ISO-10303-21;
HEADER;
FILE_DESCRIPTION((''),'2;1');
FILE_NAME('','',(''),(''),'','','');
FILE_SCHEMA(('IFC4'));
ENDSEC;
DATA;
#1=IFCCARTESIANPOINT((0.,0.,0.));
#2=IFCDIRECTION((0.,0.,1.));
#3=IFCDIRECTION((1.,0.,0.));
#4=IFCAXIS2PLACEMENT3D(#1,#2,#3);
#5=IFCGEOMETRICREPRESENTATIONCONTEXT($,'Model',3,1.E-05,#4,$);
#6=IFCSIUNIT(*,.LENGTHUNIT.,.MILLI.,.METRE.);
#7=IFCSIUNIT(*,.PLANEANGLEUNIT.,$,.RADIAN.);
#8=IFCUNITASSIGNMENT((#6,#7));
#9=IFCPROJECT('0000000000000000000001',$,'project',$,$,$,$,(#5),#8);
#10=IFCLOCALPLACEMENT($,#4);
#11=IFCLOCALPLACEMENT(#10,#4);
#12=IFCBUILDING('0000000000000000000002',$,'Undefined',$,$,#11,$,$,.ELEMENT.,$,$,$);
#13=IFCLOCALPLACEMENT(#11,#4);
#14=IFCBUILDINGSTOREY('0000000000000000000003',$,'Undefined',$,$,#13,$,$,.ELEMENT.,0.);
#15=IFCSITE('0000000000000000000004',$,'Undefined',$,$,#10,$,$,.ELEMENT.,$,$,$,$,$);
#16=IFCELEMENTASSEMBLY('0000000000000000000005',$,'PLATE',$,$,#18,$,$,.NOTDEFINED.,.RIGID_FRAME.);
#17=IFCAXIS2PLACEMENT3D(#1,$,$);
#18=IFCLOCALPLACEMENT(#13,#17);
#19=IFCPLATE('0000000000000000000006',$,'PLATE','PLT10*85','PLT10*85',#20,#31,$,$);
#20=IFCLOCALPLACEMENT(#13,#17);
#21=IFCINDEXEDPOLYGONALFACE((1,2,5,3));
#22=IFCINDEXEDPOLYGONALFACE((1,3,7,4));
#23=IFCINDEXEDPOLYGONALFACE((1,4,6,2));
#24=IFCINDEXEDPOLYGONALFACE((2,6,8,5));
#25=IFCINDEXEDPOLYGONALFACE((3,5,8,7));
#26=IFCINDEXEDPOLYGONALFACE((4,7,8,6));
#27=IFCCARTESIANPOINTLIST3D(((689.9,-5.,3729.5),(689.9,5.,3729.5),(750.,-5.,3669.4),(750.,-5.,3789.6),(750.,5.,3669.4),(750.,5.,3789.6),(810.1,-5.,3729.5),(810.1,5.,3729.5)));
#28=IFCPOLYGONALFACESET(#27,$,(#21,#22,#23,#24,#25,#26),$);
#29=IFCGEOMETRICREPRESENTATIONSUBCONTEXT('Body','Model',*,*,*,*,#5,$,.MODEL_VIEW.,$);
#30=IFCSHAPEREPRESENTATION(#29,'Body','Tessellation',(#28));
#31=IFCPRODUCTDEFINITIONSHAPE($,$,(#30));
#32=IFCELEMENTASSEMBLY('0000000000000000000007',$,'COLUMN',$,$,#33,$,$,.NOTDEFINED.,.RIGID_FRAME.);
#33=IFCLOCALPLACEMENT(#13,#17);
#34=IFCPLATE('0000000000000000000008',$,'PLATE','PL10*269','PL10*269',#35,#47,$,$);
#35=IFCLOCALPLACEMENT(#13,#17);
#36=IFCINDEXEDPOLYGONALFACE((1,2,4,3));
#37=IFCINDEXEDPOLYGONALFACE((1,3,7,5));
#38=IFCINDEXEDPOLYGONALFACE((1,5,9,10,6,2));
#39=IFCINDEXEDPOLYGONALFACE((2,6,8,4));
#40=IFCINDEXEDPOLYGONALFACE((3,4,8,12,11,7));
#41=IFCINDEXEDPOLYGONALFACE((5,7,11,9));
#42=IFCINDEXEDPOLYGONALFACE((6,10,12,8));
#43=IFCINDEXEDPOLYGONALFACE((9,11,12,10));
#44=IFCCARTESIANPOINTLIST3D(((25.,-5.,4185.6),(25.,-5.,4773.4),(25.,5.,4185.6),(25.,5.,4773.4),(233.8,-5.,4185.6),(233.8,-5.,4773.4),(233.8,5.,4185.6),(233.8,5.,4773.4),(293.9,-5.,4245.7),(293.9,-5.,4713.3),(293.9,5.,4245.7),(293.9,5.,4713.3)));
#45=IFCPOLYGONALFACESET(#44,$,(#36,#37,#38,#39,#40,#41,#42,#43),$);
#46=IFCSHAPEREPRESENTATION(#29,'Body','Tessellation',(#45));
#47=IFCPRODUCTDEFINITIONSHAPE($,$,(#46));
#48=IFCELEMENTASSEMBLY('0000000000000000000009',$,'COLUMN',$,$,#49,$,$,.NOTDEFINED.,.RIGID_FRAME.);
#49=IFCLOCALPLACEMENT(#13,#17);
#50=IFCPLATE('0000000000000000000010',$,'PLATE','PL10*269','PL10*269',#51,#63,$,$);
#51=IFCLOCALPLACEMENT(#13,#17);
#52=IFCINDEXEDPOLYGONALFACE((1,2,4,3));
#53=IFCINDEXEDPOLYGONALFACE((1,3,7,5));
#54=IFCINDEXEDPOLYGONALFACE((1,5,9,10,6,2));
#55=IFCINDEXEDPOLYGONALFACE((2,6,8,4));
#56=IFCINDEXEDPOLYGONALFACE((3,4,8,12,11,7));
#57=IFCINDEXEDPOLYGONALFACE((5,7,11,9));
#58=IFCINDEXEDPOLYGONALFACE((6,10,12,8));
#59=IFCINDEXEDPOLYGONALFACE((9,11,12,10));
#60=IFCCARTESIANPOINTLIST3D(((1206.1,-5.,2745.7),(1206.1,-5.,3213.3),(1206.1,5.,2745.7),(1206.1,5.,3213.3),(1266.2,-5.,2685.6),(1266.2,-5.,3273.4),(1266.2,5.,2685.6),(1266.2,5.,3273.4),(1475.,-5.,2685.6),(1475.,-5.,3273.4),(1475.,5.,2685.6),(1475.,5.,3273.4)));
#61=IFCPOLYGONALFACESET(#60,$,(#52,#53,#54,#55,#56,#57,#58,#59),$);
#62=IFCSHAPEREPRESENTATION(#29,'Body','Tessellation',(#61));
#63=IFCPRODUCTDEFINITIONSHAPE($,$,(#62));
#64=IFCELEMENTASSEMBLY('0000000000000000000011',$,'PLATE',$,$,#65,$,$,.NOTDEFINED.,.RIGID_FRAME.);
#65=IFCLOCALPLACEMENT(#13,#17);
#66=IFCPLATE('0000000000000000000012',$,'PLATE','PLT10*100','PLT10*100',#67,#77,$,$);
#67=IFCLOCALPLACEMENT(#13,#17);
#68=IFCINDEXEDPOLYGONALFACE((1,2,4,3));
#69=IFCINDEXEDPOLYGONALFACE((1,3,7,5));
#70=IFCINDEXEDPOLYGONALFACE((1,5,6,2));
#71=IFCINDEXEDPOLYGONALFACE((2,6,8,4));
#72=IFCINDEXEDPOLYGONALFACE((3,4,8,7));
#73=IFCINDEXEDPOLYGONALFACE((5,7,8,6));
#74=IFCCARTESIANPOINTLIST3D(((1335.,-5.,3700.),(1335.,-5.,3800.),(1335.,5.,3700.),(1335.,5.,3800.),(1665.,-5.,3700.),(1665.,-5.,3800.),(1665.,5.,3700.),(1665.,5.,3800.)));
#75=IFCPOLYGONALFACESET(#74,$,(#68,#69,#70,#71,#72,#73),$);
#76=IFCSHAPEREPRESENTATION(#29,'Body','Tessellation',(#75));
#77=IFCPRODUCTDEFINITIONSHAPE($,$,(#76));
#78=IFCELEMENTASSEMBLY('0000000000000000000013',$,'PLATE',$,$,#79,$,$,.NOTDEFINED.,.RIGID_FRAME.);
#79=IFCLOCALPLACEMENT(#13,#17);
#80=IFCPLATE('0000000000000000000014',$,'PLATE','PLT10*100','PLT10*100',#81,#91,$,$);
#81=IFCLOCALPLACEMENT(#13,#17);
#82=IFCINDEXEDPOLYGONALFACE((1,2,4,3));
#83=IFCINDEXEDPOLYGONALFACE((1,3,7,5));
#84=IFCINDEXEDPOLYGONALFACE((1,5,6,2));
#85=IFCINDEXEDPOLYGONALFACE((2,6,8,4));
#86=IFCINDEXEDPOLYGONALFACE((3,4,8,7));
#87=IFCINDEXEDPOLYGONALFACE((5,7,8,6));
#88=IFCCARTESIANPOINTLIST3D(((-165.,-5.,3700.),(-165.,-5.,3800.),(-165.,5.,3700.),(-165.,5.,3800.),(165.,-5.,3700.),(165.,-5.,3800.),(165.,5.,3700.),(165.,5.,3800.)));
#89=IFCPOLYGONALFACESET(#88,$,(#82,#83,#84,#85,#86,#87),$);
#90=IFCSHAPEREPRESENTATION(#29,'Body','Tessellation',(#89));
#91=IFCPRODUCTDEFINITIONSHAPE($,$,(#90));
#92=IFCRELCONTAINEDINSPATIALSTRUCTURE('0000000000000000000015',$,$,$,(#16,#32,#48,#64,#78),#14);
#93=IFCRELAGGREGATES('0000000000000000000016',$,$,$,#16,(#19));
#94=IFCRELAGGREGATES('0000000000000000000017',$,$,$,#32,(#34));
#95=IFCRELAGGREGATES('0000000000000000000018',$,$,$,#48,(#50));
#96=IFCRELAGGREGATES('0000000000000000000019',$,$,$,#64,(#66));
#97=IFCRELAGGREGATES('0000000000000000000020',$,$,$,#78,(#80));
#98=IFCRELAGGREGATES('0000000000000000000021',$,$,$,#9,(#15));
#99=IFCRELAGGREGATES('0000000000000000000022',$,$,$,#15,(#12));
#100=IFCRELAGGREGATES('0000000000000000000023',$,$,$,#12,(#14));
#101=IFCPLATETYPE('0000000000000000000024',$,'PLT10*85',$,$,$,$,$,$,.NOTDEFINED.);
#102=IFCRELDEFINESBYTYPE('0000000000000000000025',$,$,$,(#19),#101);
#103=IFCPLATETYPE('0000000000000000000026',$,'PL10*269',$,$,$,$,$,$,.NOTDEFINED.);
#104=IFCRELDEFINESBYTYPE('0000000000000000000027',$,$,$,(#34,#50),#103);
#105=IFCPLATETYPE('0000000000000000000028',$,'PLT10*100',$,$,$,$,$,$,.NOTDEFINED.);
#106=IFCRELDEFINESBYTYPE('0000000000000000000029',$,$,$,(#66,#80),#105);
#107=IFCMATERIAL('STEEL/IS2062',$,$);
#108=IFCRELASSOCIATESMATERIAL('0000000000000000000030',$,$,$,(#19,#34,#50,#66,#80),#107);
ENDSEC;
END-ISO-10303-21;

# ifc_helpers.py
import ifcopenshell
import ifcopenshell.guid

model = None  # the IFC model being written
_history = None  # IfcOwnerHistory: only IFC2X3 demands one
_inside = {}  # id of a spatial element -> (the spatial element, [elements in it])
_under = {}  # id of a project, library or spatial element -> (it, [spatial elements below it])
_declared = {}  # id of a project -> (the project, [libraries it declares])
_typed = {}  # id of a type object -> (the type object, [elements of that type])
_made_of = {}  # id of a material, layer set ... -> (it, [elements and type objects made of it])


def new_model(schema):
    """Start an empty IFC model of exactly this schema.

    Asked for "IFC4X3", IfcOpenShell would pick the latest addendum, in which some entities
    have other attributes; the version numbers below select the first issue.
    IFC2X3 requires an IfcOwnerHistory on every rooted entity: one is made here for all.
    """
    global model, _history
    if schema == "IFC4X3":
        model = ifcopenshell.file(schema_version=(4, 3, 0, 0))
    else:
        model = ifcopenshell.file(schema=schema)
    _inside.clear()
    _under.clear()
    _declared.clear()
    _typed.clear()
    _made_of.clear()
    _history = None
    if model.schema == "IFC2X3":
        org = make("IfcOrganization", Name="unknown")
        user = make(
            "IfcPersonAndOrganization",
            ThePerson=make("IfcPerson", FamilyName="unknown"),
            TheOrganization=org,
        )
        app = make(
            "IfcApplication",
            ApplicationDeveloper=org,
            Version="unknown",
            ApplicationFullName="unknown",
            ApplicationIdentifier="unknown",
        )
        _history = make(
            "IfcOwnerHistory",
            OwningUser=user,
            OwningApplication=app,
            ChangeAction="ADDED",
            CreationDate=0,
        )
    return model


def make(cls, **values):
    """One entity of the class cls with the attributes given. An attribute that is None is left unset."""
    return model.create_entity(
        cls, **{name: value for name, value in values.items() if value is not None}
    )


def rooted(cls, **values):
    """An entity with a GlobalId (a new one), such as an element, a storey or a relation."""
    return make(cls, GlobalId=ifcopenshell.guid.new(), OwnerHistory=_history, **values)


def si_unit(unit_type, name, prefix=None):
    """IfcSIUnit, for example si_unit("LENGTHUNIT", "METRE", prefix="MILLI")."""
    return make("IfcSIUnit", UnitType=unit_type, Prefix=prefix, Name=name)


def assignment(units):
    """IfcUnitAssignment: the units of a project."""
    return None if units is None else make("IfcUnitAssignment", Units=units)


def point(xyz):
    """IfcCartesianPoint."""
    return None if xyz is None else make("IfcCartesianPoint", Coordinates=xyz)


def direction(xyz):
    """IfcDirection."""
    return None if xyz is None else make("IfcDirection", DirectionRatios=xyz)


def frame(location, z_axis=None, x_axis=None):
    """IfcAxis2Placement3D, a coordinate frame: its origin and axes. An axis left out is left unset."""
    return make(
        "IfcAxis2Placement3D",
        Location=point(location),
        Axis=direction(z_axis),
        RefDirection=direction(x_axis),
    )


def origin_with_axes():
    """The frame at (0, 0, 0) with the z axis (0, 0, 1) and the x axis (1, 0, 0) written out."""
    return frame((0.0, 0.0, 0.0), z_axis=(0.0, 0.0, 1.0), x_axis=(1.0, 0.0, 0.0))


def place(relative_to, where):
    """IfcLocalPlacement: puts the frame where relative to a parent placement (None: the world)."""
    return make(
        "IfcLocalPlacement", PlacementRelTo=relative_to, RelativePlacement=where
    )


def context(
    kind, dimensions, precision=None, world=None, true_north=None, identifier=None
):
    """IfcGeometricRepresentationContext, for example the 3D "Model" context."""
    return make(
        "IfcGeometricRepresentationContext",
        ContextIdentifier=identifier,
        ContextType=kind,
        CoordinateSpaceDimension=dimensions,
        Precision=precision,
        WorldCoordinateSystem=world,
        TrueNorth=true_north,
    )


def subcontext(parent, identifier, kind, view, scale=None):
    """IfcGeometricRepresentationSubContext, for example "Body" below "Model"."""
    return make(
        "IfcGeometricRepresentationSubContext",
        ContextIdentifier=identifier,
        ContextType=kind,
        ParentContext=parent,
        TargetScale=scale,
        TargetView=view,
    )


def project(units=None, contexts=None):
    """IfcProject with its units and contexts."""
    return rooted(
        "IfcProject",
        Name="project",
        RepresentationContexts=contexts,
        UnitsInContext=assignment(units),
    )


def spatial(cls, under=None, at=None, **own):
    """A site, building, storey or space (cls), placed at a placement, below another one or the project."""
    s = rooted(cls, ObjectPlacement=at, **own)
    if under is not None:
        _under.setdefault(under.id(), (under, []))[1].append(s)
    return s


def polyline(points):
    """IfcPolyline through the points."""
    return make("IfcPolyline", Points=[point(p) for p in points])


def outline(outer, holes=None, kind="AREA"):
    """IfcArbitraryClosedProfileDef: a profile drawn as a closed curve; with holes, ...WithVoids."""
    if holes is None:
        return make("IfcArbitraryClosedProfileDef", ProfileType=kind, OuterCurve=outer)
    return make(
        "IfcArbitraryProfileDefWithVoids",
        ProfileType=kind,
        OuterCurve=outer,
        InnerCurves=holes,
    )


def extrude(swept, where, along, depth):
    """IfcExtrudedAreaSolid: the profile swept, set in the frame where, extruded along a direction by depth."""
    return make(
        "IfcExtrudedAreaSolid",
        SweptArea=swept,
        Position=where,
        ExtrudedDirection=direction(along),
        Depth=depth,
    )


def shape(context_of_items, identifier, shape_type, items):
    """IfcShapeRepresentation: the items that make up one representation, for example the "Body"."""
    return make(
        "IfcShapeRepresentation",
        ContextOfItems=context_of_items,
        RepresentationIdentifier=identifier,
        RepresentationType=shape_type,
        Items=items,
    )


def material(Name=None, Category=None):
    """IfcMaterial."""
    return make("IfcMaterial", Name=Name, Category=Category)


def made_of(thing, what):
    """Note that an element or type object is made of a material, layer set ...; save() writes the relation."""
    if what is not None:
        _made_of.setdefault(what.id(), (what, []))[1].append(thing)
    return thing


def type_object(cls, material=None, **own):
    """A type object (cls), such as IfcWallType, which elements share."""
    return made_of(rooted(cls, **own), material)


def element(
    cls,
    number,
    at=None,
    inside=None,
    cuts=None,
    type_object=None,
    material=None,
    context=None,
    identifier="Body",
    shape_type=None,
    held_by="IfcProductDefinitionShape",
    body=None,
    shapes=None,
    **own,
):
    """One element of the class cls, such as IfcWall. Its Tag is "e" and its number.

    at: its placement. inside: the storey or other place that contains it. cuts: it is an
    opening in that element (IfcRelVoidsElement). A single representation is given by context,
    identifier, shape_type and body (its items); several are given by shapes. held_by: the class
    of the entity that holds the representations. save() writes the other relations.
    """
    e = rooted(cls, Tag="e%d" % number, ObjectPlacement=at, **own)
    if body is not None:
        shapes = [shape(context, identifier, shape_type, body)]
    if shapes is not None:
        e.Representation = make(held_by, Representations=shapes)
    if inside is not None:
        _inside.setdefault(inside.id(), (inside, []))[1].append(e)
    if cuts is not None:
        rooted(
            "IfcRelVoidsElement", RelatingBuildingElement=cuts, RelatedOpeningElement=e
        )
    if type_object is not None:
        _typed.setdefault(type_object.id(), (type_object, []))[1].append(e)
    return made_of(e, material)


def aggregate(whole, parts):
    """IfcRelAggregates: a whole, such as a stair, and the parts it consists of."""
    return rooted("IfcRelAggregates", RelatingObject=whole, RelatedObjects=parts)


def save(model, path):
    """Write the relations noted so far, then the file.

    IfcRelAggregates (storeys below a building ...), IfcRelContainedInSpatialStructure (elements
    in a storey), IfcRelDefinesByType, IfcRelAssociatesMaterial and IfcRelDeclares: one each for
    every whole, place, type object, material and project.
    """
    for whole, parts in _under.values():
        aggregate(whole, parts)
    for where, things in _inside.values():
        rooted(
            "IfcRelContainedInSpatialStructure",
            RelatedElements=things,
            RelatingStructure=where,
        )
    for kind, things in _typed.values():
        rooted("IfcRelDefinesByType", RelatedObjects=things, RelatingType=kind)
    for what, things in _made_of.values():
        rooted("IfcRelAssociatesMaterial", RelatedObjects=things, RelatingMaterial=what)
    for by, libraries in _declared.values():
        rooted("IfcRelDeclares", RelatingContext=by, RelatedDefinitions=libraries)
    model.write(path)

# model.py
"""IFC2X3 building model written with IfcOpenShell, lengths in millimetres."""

from ifc_helpers import new_model, si_unit, frame, origin_with_axes, place, context, subcontext, project, spatial, polyline, outline, extrude, material, type_object, element, aggregate, save


model = new_model("IFC2X3")

# Units and contexts
model_context = context("Model", 3, precision=1e-05, world=origin_with_axes())
body_context = subcontext(model_context, "Body", "Model", "MODEL_VIEW")
ifc_project = project(units=[si_unit("LENGTHUNIT", "METRE", prefix="MILLI"), si_unit("PLANEANGLEUNIT", "RADIAN")], contexts=[model_context])

# Site, building, storey
site_placement = place(None, origin_with_axes())
site = spatial("IfcSite", under=ifc_project, at=site_placement, Name="Undefined", CompositionType="ELEMENT")
building_placement = place(site_placement, origin_with_axes())
building = spatial("IfcBuilding", under=site, at=building_placement, Name="Undefined", CompositionType="ELEMENT")
storey_placement = place(building_placement, origin_with_axes())
storey = spatial("IfcBuildingStorey", under=building, at=storey_placement, Name="Undefined", CompositionType="ELEMENT", Elevation=0.0)

# Shared definitions
ifc_material = material(Name="STEEL/IS2062")

# Element assemblies, plates
assembly_1_placement = place(storey_placement, origin_with_axes())
assembly_1 = element("IfcElementAssembly", 1, at=assembly_1_placement, inside=storey, Name="PLATE", AssemblyPlace="NOTDEFINED", PredefinedType="RIGID_FRAME")
plate_type_1 = type_object("IfcPlateType", Name="PLT10*85", PredefinedType="NOTDEFINED")
plate_1_placement = place(assembly_1_placement, frame((750.0, 0.0, 3789.6), z_axis=(0.0, -1.0, 0.0), x_axis=(-0.707107, 0.0, -0.707107)))
plate_1 = element("IfcPlate", 2, at=plate_1_placement, type_object=plate_type_1, material=ifc_material, Name="PLATE", Description="PLT10*85", ObjectType="PLT10*85", context=body_context, shape_type="SweptSolid", body=[
    extrude(outline(polyline([(0.0, 0.0), (85.0, 0.0), (85.0, 85.0), (0.0, 85.0), (0.0, 0.0)])), frame((0.0, 0.0, -5.0), z_axis=(0.0, 0.0, 1.0), x_axis=(1.0, 0.0, 0.0)), (0.0, 0.0, 1.0), 10.0),
])
aggregate(assembly_1, [plate_1])
assembly_2_placement = place(storey_placement, origin_with_axes())
assembly_2 = element("IfcElementAssembly", 3, at=assembly_2_placement, inside=storey, Name="COLUMN", AssemblyPlace="NOTDEFINED", PredefinedType="RIGID_FRAME")
plate_type_2 = type_object("IfcPlateType", Name="PL10*269", PredefinedType="NOTDEFINED")
plate_2_placement = place(assembly_2_placement, frame((25.0, 0.0, 4185.6), z_axis=(0.0, 1.0, 0.0), x_axis=(0.0, 0.0, 1.0)))
plate_2 = element("IfcPlate", 4, at=plate_2_placement, type_object=plate_type_2, material=ifc_material, Name="PLATE", Description="PL10*269", ObjectType="PL10*269", context=body_context, shape_type="SweptSolid", body=[
    extrude(outline(polyline([(0.0, 0.0), (587.8, 0.0), (587.8, 208.8), (527.7, 268.9), (60.1, 268.9), (0.0, 208.8), (0.0, 0.0)])), frame((0.0, 0.0, -5.0), z_axis=(0.0, 0.0, 1.0), x_axis=(1.0, 0.0, 0.0)), (0.0, 0.0, 1.0), 10.0),
])
aggregate(assembly_2, [plate_2])
assembly_3_placement = place(storey_placement, origin_with_axes())
assembly_3 = element("IfcElementAssembly", 5, at=assembly_3_placement, inside=storey, Name="COLUMN", AssemblyPlace="NOTDEFINED", PredefinedType="RIGID_FRAME")
plate_3_placement = place(assembly_3_placement, frame((1475.0, 0.0, 3273.4), z_axis=(0.0, 1.0, 0.0), x_axis=(0.0, 0.0, -1.0)))
plate_3 = element("IfcPlate", 6, at=plate_3_placement, type_object=plate_type_2, material=ifc_material, Name="PLATE", Description="PL10*269", ObjectType="PL10*269", context=body_context, shape_type="SweptSolid", body=[
    extrude(outline(polyline([(0.0, 0.0), (587.8, 0.0), (587.8, 208.8), (527.7, 268.9), (60.1, 268.9), (0.0, 208.8), (0.0, 0.0)])), frame((0.0, 0.0, -5.0), z_axis=(0.0, 0.0, 1.0), x_axis=(1.0, 0.0, 0.0)), (0.0, 0.0, 1.0), 10.0),
])
aggregate(assembly_3, [plate_3])
assembly_4_placement = place(storey_placement, origin_with_axes())
assembly_4 = element("IfcElementAssembly", 7, at=assembly_4_placement, inside=storey, Name="PLATE", AssemblyPlace="NOTDEFINED", PredefinedType="RIGID_FRAME")
plate_type_3 = type_object("IfcPlateType", Name="PLT10*100", PredefinedType="NOTDEFINED")
plate_4_placement = place(assembly_4_placement, frame((1335.0, 0.0, 3800.0), z_axis=(0.0, 1.0, 0.0), x_axis=(1.0, 0.0, 0.0)))
plate_4 = element("IfcPlate", 8, at=plate_4_placement, type_object=plate_type_3, material=ifc_material, Name="PLATE", Description="PLT10*100", ObjectType="PLT10*100", context=body_context, shape_type="SweptSolid", body=[
    extrude(outline(polyline([(0.0, 0.0), (330.0, 0.0), (330.0, 100.0), (0.0, 100.0), (0.0, 0.0)])), frame((0.0, 0.0, -5.0), z_axis=(0.0, 0.0, 1.0), x_axis=(1.0, 0.0, 0.0)), (0.0, 0.0, 1.0), 10.0),
])
aggregate(assembly_4, [plate_4])
assembly_5_placement = place(storey_placement, origin_with_axes())
assembly_5 = element("IfcElementAssembly", 9, at=assembly_5_placement, inside=storey, Name="PLATE", AssemblyPlace="NOTDEFINED", PredefinedType="RIGID_FRAME")
plate_5_placement = place(assembly_5_placement, frame((165.0, 0.0, 3800.0), z_axis=(0.0, -1.0, 0.0), x_axis=(-1.0, 0.0, 0.0)))
plate_5 = element("IfcPlate", 10, at=plate_5_placement, type_object=plate_type_3, material=ifc_material, Name="PLATE", Description="PLT10*100", ObjectType="PLT10*100", context=body_context, shape_type="SweptSolid", body=[
    extrude(outline(polyline([(0.0, 0.0), (330.0, 0.0), (330.0, 100.0), (0.0, 100.0), (0.0, 0.0)])), frame((0.0, 0.0, -5.0), z_axis=(0.0, 0.0, 1.0), x_axis=(1.0, 0.0, 0.0)), (0.0, 0.0, 1.0), 10.0),
])
aggregate(assembly_5, [plate_5])

save(model, "model.ifc")
